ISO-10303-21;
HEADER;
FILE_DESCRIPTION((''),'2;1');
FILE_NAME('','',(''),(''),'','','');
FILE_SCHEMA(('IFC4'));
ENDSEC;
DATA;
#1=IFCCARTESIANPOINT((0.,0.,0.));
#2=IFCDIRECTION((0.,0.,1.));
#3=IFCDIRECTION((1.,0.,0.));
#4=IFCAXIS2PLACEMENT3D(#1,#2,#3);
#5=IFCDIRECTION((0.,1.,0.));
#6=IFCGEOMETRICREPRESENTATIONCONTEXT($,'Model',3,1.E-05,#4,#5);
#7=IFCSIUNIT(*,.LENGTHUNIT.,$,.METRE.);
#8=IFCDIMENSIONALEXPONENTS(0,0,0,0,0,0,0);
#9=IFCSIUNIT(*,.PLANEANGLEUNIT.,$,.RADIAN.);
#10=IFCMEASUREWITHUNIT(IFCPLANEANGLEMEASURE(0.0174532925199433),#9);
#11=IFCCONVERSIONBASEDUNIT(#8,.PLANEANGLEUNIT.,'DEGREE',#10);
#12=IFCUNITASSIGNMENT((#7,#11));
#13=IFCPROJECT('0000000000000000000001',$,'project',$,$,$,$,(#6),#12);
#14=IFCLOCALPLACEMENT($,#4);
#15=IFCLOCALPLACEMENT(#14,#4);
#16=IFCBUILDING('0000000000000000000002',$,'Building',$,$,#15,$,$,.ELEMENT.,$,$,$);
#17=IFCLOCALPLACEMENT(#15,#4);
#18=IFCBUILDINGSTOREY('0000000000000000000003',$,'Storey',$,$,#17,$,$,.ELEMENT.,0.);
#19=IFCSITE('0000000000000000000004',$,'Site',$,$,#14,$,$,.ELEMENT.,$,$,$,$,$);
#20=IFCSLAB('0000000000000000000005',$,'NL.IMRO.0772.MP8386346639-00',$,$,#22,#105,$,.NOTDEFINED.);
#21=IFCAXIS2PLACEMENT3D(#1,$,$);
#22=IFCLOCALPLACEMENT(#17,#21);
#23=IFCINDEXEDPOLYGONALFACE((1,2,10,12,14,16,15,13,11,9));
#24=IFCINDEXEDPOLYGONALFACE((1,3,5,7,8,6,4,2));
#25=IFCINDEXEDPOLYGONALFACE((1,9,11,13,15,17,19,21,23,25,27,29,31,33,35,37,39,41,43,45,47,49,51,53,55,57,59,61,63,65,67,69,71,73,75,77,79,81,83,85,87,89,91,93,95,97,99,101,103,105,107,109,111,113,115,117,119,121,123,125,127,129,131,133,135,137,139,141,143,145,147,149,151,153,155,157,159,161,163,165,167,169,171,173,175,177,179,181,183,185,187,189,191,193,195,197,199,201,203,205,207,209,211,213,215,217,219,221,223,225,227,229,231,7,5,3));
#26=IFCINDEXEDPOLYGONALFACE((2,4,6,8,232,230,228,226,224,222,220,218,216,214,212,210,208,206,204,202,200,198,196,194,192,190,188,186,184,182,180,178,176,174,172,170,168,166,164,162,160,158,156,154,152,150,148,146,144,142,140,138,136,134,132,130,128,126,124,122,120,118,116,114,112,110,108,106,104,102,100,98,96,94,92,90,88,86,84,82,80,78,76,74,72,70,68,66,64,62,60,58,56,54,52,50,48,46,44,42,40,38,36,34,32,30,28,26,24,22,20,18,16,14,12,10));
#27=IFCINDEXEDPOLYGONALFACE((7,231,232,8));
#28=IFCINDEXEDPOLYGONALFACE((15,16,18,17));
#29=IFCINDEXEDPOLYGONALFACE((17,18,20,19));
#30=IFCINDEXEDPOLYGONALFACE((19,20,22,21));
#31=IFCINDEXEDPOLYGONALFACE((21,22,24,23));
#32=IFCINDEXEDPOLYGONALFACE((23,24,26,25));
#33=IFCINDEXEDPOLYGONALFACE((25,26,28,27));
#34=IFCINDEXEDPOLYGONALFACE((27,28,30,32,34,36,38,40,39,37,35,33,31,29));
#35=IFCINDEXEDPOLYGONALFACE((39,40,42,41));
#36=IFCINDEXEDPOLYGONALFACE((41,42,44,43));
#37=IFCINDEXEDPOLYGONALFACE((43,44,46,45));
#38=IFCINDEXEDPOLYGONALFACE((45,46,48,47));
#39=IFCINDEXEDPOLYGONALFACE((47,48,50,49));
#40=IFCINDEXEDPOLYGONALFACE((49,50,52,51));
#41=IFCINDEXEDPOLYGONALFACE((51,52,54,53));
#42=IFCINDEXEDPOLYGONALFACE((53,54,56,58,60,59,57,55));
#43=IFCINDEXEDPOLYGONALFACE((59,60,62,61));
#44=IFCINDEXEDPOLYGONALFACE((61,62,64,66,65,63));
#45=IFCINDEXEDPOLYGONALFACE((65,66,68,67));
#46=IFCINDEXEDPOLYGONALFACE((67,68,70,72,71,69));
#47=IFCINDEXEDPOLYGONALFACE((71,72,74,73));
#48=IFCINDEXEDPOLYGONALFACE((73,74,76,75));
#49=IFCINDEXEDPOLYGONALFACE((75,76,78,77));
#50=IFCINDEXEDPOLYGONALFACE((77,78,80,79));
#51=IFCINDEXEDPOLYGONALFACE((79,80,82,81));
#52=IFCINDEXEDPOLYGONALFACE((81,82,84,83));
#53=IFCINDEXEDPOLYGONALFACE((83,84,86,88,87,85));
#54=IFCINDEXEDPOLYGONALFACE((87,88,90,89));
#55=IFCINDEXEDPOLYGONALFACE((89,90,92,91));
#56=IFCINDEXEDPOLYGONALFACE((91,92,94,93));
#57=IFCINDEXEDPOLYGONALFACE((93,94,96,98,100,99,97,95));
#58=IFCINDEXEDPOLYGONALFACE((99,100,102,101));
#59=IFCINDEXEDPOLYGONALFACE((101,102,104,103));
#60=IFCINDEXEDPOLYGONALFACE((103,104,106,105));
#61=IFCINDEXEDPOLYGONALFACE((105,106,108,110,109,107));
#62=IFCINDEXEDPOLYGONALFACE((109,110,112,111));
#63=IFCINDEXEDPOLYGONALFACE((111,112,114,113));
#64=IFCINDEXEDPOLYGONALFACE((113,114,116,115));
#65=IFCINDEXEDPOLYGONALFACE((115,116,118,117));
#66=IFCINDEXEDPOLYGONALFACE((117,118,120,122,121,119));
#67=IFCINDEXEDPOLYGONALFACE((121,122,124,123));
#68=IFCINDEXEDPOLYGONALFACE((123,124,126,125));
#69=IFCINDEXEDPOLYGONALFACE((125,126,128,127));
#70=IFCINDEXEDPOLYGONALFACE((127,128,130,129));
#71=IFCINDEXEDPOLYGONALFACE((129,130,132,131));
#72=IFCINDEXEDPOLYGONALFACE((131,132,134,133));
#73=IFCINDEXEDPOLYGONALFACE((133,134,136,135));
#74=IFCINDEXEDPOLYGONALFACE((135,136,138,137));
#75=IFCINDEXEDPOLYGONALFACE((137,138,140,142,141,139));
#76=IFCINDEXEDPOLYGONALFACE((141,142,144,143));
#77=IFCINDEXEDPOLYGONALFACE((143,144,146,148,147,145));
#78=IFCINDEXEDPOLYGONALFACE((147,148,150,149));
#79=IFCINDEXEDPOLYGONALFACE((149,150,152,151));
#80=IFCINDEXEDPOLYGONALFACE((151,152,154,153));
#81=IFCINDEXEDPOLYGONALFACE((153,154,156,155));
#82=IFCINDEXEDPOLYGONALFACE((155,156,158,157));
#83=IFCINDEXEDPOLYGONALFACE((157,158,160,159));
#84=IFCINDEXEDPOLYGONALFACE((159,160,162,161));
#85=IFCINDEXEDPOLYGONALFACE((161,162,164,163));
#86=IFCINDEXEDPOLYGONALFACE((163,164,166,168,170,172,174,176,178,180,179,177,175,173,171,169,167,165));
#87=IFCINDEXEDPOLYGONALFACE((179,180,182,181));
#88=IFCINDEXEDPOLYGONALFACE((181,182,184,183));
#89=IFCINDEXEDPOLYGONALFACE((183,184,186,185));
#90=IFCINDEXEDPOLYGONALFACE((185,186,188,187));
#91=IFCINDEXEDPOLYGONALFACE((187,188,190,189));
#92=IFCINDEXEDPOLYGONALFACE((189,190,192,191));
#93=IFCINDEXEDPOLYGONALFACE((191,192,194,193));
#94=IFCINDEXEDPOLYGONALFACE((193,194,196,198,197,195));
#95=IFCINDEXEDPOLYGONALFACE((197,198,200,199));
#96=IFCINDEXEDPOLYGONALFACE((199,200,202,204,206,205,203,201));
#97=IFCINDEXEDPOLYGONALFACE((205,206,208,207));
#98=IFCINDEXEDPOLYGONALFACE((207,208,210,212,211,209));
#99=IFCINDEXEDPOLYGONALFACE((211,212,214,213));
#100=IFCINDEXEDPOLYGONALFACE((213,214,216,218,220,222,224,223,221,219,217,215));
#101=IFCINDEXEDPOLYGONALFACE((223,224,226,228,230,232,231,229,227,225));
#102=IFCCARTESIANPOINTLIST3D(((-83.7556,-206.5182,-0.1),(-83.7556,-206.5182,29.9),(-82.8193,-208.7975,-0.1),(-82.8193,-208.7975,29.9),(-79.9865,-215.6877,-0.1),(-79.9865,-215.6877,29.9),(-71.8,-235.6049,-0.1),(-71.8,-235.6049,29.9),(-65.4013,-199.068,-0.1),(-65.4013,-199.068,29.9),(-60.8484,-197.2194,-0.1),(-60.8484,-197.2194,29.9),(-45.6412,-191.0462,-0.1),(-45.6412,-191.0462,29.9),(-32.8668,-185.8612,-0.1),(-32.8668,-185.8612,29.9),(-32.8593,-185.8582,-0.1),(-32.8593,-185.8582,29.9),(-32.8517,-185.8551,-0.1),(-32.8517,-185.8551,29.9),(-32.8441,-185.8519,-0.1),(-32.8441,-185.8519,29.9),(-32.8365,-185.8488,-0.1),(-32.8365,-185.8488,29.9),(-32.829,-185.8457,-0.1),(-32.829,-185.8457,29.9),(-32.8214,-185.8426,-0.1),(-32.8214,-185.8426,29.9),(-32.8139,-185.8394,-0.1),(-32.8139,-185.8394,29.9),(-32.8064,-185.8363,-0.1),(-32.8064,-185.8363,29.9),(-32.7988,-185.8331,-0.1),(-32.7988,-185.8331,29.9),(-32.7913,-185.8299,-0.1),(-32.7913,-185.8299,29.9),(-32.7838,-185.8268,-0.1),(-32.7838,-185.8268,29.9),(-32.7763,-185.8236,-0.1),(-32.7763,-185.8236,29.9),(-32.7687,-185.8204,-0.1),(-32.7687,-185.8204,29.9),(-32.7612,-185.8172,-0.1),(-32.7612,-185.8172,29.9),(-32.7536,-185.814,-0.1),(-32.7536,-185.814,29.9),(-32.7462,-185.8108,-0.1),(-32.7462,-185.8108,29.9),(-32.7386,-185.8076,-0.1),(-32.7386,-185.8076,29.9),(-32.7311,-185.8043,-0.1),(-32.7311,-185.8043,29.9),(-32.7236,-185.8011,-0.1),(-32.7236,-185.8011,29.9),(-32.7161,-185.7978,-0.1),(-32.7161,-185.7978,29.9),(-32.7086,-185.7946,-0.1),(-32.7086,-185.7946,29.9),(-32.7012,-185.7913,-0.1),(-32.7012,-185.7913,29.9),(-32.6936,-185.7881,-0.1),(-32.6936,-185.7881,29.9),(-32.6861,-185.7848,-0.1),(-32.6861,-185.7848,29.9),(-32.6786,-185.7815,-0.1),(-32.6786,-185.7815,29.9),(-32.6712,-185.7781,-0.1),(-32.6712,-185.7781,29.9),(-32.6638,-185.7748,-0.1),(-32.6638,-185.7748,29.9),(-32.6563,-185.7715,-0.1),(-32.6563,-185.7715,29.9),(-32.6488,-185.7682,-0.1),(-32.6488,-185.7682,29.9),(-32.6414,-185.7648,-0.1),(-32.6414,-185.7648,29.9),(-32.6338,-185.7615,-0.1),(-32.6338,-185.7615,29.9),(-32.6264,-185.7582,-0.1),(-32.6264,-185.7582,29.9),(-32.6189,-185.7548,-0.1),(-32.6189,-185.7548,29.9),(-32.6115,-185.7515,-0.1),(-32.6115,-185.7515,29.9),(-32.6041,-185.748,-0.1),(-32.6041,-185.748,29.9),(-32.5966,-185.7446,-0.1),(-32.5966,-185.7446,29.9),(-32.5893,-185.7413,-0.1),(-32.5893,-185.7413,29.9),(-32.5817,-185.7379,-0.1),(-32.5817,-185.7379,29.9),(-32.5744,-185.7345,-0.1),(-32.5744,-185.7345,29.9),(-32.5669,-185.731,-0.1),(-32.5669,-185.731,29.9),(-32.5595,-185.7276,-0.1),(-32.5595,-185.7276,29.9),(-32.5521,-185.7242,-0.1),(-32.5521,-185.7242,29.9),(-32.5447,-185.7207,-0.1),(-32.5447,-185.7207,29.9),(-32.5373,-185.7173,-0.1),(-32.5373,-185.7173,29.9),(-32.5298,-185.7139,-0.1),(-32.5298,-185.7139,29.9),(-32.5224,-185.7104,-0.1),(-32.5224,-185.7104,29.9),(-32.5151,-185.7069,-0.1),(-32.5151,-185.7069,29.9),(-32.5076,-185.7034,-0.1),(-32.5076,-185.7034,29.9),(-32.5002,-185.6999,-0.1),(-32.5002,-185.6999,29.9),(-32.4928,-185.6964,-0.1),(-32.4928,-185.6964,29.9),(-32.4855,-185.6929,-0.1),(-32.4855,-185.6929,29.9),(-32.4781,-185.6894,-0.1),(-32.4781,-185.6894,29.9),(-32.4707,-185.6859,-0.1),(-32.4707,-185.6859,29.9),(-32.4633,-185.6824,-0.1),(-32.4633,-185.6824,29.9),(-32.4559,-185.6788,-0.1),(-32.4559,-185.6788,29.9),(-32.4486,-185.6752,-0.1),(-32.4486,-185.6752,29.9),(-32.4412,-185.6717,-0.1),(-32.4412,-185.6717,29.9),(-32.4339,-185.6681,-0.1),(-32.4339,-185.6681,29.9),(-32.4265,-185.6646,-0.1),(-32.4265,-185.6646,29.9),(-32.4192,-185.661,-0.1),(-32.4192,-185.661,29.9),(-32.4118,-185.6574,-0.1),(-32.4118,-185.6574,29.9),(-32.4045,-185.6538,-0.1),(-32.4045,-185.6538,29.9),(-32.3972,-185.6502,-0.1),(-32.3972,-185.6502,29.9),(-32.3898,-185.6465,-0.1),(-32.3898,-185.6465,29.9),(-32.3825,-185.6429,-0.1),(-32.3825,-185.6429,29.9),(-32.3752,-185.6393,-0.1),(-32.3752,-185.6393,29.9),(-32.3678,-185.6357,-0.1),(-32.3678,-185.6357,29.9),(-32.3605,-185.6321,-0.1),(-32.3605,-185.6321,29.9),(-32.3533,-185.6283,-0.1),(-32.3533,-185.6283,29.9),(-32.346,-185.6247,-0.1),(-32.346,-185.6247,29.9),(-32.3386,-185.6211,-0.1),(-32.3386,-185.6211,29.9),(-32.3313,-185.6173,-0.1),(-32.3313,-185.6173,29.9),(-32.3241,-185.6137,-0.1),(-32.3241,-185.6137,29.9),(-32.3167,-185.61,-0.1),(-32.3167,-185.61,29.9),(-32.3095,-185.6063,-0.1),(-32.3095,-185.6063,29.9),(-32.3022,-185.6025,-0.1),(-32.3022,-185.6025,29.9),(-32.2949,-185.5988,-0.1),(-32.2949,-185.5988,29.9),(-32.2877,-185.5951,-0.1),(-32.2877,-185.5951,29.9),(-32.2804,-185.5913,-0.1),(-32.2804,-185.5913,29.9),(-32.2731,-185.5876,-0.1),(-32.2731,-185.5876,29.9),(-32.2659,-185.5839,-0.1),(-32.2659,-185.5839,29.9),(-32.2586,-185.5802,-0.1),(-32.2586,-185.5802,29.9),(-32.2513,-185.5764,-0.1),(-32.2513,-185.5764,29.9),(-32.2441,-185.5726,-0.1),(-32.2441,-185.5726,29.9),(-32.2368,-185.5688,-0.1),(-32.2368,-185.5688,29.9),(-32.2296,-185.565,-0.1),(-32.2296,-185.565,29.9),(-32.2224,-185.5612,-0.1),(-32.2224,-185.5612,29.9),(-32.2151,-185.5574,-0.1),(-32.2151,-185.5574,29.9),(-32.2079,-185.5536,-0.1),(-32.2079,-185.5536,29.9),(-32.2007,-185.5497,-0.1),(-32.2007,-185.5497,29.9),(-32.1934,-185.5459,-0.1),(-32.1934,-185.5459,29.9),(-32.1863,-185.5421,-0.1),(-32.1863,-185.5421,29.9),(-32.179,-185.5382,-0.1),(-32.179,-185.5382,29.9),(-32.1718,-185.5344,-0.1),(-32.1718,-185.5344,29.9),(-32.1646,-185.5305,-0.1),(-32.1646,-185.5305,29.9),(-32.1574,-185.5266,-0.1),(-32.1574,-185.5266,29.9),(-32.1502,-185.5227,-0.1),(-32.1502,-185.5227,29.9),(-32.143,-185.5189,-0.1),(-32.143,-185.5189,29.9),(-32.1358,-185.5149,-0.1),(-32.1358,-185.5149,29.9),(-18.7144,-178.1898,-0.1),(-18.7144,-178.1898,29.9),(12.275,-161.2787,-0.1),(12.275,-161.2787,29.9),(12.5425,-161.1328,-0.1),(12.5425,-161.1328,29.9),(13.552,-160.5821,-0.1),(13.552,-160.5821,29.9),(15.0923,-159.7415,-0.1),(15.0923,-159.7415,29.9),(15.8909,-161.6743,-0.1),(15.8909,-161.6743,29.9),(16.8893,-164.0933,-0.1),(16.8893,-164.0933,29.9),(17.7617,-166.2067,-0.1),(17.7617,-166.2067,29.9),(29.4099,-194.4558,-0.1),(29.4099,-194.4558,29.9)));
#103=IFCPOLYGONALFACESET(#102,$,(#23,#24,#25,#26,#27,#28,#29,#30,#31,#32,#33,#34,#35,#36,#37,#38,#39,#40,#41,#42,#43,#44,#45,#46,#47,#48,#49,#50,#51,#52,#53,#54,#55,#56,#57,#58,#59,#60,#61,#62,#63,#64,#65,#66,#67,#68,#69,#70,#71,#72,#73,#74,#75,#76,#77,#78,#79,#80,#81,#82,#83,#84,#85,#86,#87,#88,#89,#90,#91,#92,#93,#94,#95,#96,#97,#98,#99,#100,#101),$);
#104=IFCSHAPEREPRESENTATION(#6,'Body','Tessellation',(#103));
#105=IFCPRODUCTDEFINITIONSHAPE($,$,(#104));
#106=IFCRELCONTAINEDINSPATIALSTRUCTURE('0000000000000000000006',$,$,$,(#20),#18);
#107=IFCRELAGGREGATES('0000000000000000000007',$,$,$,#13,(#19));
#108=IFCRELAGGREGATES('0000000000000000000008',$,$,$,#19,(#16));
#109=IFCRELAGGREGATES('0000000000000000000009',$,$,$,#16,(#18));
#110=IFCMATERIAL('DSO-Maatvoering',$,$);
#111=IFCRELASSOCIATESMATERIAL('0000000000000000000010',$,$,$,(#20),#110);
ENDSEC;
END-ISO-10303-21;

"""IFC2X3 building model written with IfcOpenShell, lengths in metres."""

from ifc_helpers import new_model, entity, si_unit, converted_unit, direction, frame, origin_with_axes, place, context, project, spatial, polyline, outline, extrude, material, element, save


model = new_model("IFC2X3")

# Units and contexts
model_context = context("Model", 3, precision=1e-05, world=origin_with_axes(), true_north=direction((0.0, 1.0, 0.0)))
ifc_project = project(units=[si_unit("LENGTHUNIT", "METRE"), converted_unit("PLANEANGLEUNIT", "DEGREE", entity("IfcPlaneAngleMeasure", 0.0174532925199433), si_unit("PLANEANGLEUNIT", "RADIAN"), dimensions=[0, 0, 0, 0, 0, 0, 0])], contexts=[model_context])

# Site, building, storey
site_placement = place(None, origin_with_axes())
site = spatial("IfcSite", under=ifc_project, at=site_placement, Name="Site", CompositionType="ELEMENT")
building_placement = place(site_placement, origin_with_axes())
building = spatial("IfcBuilding", under=site, at=building_placement, Name="Building", CompositionType="ELEMENT")
storey_placement = place(building_placement, origin_with_axes())
storey = spatial("IfcBuildingStorey", under=building, at=storey_placement, Name="Storey", CompositionType="ELEMENT", Elevation=0.0)

# Slab
ifc_material = material(Name="DSO-Maatvoering")
slab_1_placement = place(storey_placement, frame((0.0, 0.0, -0.1), z_axis=(0.0, 0.0, 1.0), x_axis=(1.0, 0.0, 0.0)))
element("IfcSlab", 1, at=slab_1_placement, inside=storey, material=ifc_material, Name="NL.IMRO.0772.MP8386346639-00", PredefinedType="NOTDEFINED", context=model_context, shape_type="SweptSolid", body=[
    extrude(outline(polyline([(-18.7144, -178.1898), (12.275, -161.2787), (12.5425, -161.1328), (13.552, -160.5821), (15.0923, -159.7415), (15.8909, -161.6743), (16.8893, -164.0933), (17.7617, -166.2067), (29.4099, -194.4558), (-71.8, -235.6049), (-79.9865, -215.6877), (-82.8193, -208.7975), (-83.7556, -206.5182), (-65.4013, -199.068), (-60.8484, -197.2194), (-45.6412, -191.0462), (-32.8668, -185.8612), (-32.8593, -185.8582), (-32.8517, -185.8551), (-32.8441, -185.8519), (-32.8365, -185.8488), (-32.829, -185.8457), (-32.8214, -185.8426), (-32.8139, -185.8394), (-32.8064, -185.8363), (-32.7988, -185.8331), (-32.7913, -185.8299), (-32.7838, -185.8268), (-32.7763, -185.8236), (-32.7687, -185.8204), (-32.7612, -185.8172), (-32.7536, -185.814), (-32.7462, -185.8108), (-32.7386, -185.8076), (-32.7311, -185.8043), (-32.7236, -185.8011), (-32.7161, -185.7978), (-32.7086, -185.7946), (-32.7012, -185.7913), (-32.6936, -185.7881), (-32.6861, -185.7848), (-32.6786, -185.7815), (-32.6712, -185.7781), (-32.6638, -185.7748), (-32.6563, -185.7715), (-32.6488, -185.7682), (-32.6414, -185.7648), (-32.6338, -185.7615), (-32.6264, -185.7582), (-32.6189, -185.7548), (-32.6115, -185.7515), (-32.6041, -185.748), (-32.5966, -185.7446), (-32.5893, -185.7413), (-32.5817, -185.7379), (-32.5744, -185.7345), (-32.5669, -185.731), (-32.5595, -185.7276), (-32.5521, -185.7242), (-32.5447, -185.7207), (-32.5373, -185.7173), (-32.5298, -185.7139), (-32.5224, -185.7104), (-32.5151, -185.7069), (-32.5076, -185.7034), (-32.5002, -185.6999), (-32.4928, -185.6964), (-32.4855, -185.6929), (-32.4781, -185.6894), (-32.4707, -185.6859), (-32.4633, -185.6824), (-32.4559, -185.6788), (-32.4486, -185.6752), (-32.4412, -185.6717), (-32.4339, -185.6681), (-32.4265, -185.6646), (-32.4192, -185.661), (-32.4118, -185.6574), (-32.4045, -185.6538), (-32.3972, -185.6502), (-32.3898, -185.6465), (-32.3825, -185.6429), (-32.3752, -185.6393), (-32.3678, -185.6357), (-32.3605, -185.6321), (-32.3533, -185.6283), (-32.346, -185.6247), (-32.3386, -185.6211), (-32.3313, -185.6173), (-32.3241, -185.6137), (-32.3167, -185.61), (-32.3095, -185.6063), (-32.3022, -185.6025), (-32.2949, -185.5988), (-32.2877, -185.5951), (-32.2804, -185.5913), (-32.2731, -185.5876), (-32.2659, -185.5839), (-32.2586, -185.5802), (-32.2513, -185.5764), (-32.2441, -185.5726), (-32.2368, -185.5688), (-32.2296, -185.565), (-32.2224, -185.5612), (-32.2151, -185.5574), (-32.2079, -185.5536), (-32.2007, -185.5497), (-32.1934, -185.5459), (-32.1863, -185.5421), (-32.179, -185.5382), (-32.1718, -185.5344), (-32.1646, -185.5305), (-32.1574, -185.5266), (-32.1502, -185.5227), (-32.143, -185.5189), (-32.1358, -185.5149), (-18.7144, -178.1898)])), origin_with_axes(), (0.0, 0.0, 1.0), 30.0),
])

save(model, "model.ifc")
